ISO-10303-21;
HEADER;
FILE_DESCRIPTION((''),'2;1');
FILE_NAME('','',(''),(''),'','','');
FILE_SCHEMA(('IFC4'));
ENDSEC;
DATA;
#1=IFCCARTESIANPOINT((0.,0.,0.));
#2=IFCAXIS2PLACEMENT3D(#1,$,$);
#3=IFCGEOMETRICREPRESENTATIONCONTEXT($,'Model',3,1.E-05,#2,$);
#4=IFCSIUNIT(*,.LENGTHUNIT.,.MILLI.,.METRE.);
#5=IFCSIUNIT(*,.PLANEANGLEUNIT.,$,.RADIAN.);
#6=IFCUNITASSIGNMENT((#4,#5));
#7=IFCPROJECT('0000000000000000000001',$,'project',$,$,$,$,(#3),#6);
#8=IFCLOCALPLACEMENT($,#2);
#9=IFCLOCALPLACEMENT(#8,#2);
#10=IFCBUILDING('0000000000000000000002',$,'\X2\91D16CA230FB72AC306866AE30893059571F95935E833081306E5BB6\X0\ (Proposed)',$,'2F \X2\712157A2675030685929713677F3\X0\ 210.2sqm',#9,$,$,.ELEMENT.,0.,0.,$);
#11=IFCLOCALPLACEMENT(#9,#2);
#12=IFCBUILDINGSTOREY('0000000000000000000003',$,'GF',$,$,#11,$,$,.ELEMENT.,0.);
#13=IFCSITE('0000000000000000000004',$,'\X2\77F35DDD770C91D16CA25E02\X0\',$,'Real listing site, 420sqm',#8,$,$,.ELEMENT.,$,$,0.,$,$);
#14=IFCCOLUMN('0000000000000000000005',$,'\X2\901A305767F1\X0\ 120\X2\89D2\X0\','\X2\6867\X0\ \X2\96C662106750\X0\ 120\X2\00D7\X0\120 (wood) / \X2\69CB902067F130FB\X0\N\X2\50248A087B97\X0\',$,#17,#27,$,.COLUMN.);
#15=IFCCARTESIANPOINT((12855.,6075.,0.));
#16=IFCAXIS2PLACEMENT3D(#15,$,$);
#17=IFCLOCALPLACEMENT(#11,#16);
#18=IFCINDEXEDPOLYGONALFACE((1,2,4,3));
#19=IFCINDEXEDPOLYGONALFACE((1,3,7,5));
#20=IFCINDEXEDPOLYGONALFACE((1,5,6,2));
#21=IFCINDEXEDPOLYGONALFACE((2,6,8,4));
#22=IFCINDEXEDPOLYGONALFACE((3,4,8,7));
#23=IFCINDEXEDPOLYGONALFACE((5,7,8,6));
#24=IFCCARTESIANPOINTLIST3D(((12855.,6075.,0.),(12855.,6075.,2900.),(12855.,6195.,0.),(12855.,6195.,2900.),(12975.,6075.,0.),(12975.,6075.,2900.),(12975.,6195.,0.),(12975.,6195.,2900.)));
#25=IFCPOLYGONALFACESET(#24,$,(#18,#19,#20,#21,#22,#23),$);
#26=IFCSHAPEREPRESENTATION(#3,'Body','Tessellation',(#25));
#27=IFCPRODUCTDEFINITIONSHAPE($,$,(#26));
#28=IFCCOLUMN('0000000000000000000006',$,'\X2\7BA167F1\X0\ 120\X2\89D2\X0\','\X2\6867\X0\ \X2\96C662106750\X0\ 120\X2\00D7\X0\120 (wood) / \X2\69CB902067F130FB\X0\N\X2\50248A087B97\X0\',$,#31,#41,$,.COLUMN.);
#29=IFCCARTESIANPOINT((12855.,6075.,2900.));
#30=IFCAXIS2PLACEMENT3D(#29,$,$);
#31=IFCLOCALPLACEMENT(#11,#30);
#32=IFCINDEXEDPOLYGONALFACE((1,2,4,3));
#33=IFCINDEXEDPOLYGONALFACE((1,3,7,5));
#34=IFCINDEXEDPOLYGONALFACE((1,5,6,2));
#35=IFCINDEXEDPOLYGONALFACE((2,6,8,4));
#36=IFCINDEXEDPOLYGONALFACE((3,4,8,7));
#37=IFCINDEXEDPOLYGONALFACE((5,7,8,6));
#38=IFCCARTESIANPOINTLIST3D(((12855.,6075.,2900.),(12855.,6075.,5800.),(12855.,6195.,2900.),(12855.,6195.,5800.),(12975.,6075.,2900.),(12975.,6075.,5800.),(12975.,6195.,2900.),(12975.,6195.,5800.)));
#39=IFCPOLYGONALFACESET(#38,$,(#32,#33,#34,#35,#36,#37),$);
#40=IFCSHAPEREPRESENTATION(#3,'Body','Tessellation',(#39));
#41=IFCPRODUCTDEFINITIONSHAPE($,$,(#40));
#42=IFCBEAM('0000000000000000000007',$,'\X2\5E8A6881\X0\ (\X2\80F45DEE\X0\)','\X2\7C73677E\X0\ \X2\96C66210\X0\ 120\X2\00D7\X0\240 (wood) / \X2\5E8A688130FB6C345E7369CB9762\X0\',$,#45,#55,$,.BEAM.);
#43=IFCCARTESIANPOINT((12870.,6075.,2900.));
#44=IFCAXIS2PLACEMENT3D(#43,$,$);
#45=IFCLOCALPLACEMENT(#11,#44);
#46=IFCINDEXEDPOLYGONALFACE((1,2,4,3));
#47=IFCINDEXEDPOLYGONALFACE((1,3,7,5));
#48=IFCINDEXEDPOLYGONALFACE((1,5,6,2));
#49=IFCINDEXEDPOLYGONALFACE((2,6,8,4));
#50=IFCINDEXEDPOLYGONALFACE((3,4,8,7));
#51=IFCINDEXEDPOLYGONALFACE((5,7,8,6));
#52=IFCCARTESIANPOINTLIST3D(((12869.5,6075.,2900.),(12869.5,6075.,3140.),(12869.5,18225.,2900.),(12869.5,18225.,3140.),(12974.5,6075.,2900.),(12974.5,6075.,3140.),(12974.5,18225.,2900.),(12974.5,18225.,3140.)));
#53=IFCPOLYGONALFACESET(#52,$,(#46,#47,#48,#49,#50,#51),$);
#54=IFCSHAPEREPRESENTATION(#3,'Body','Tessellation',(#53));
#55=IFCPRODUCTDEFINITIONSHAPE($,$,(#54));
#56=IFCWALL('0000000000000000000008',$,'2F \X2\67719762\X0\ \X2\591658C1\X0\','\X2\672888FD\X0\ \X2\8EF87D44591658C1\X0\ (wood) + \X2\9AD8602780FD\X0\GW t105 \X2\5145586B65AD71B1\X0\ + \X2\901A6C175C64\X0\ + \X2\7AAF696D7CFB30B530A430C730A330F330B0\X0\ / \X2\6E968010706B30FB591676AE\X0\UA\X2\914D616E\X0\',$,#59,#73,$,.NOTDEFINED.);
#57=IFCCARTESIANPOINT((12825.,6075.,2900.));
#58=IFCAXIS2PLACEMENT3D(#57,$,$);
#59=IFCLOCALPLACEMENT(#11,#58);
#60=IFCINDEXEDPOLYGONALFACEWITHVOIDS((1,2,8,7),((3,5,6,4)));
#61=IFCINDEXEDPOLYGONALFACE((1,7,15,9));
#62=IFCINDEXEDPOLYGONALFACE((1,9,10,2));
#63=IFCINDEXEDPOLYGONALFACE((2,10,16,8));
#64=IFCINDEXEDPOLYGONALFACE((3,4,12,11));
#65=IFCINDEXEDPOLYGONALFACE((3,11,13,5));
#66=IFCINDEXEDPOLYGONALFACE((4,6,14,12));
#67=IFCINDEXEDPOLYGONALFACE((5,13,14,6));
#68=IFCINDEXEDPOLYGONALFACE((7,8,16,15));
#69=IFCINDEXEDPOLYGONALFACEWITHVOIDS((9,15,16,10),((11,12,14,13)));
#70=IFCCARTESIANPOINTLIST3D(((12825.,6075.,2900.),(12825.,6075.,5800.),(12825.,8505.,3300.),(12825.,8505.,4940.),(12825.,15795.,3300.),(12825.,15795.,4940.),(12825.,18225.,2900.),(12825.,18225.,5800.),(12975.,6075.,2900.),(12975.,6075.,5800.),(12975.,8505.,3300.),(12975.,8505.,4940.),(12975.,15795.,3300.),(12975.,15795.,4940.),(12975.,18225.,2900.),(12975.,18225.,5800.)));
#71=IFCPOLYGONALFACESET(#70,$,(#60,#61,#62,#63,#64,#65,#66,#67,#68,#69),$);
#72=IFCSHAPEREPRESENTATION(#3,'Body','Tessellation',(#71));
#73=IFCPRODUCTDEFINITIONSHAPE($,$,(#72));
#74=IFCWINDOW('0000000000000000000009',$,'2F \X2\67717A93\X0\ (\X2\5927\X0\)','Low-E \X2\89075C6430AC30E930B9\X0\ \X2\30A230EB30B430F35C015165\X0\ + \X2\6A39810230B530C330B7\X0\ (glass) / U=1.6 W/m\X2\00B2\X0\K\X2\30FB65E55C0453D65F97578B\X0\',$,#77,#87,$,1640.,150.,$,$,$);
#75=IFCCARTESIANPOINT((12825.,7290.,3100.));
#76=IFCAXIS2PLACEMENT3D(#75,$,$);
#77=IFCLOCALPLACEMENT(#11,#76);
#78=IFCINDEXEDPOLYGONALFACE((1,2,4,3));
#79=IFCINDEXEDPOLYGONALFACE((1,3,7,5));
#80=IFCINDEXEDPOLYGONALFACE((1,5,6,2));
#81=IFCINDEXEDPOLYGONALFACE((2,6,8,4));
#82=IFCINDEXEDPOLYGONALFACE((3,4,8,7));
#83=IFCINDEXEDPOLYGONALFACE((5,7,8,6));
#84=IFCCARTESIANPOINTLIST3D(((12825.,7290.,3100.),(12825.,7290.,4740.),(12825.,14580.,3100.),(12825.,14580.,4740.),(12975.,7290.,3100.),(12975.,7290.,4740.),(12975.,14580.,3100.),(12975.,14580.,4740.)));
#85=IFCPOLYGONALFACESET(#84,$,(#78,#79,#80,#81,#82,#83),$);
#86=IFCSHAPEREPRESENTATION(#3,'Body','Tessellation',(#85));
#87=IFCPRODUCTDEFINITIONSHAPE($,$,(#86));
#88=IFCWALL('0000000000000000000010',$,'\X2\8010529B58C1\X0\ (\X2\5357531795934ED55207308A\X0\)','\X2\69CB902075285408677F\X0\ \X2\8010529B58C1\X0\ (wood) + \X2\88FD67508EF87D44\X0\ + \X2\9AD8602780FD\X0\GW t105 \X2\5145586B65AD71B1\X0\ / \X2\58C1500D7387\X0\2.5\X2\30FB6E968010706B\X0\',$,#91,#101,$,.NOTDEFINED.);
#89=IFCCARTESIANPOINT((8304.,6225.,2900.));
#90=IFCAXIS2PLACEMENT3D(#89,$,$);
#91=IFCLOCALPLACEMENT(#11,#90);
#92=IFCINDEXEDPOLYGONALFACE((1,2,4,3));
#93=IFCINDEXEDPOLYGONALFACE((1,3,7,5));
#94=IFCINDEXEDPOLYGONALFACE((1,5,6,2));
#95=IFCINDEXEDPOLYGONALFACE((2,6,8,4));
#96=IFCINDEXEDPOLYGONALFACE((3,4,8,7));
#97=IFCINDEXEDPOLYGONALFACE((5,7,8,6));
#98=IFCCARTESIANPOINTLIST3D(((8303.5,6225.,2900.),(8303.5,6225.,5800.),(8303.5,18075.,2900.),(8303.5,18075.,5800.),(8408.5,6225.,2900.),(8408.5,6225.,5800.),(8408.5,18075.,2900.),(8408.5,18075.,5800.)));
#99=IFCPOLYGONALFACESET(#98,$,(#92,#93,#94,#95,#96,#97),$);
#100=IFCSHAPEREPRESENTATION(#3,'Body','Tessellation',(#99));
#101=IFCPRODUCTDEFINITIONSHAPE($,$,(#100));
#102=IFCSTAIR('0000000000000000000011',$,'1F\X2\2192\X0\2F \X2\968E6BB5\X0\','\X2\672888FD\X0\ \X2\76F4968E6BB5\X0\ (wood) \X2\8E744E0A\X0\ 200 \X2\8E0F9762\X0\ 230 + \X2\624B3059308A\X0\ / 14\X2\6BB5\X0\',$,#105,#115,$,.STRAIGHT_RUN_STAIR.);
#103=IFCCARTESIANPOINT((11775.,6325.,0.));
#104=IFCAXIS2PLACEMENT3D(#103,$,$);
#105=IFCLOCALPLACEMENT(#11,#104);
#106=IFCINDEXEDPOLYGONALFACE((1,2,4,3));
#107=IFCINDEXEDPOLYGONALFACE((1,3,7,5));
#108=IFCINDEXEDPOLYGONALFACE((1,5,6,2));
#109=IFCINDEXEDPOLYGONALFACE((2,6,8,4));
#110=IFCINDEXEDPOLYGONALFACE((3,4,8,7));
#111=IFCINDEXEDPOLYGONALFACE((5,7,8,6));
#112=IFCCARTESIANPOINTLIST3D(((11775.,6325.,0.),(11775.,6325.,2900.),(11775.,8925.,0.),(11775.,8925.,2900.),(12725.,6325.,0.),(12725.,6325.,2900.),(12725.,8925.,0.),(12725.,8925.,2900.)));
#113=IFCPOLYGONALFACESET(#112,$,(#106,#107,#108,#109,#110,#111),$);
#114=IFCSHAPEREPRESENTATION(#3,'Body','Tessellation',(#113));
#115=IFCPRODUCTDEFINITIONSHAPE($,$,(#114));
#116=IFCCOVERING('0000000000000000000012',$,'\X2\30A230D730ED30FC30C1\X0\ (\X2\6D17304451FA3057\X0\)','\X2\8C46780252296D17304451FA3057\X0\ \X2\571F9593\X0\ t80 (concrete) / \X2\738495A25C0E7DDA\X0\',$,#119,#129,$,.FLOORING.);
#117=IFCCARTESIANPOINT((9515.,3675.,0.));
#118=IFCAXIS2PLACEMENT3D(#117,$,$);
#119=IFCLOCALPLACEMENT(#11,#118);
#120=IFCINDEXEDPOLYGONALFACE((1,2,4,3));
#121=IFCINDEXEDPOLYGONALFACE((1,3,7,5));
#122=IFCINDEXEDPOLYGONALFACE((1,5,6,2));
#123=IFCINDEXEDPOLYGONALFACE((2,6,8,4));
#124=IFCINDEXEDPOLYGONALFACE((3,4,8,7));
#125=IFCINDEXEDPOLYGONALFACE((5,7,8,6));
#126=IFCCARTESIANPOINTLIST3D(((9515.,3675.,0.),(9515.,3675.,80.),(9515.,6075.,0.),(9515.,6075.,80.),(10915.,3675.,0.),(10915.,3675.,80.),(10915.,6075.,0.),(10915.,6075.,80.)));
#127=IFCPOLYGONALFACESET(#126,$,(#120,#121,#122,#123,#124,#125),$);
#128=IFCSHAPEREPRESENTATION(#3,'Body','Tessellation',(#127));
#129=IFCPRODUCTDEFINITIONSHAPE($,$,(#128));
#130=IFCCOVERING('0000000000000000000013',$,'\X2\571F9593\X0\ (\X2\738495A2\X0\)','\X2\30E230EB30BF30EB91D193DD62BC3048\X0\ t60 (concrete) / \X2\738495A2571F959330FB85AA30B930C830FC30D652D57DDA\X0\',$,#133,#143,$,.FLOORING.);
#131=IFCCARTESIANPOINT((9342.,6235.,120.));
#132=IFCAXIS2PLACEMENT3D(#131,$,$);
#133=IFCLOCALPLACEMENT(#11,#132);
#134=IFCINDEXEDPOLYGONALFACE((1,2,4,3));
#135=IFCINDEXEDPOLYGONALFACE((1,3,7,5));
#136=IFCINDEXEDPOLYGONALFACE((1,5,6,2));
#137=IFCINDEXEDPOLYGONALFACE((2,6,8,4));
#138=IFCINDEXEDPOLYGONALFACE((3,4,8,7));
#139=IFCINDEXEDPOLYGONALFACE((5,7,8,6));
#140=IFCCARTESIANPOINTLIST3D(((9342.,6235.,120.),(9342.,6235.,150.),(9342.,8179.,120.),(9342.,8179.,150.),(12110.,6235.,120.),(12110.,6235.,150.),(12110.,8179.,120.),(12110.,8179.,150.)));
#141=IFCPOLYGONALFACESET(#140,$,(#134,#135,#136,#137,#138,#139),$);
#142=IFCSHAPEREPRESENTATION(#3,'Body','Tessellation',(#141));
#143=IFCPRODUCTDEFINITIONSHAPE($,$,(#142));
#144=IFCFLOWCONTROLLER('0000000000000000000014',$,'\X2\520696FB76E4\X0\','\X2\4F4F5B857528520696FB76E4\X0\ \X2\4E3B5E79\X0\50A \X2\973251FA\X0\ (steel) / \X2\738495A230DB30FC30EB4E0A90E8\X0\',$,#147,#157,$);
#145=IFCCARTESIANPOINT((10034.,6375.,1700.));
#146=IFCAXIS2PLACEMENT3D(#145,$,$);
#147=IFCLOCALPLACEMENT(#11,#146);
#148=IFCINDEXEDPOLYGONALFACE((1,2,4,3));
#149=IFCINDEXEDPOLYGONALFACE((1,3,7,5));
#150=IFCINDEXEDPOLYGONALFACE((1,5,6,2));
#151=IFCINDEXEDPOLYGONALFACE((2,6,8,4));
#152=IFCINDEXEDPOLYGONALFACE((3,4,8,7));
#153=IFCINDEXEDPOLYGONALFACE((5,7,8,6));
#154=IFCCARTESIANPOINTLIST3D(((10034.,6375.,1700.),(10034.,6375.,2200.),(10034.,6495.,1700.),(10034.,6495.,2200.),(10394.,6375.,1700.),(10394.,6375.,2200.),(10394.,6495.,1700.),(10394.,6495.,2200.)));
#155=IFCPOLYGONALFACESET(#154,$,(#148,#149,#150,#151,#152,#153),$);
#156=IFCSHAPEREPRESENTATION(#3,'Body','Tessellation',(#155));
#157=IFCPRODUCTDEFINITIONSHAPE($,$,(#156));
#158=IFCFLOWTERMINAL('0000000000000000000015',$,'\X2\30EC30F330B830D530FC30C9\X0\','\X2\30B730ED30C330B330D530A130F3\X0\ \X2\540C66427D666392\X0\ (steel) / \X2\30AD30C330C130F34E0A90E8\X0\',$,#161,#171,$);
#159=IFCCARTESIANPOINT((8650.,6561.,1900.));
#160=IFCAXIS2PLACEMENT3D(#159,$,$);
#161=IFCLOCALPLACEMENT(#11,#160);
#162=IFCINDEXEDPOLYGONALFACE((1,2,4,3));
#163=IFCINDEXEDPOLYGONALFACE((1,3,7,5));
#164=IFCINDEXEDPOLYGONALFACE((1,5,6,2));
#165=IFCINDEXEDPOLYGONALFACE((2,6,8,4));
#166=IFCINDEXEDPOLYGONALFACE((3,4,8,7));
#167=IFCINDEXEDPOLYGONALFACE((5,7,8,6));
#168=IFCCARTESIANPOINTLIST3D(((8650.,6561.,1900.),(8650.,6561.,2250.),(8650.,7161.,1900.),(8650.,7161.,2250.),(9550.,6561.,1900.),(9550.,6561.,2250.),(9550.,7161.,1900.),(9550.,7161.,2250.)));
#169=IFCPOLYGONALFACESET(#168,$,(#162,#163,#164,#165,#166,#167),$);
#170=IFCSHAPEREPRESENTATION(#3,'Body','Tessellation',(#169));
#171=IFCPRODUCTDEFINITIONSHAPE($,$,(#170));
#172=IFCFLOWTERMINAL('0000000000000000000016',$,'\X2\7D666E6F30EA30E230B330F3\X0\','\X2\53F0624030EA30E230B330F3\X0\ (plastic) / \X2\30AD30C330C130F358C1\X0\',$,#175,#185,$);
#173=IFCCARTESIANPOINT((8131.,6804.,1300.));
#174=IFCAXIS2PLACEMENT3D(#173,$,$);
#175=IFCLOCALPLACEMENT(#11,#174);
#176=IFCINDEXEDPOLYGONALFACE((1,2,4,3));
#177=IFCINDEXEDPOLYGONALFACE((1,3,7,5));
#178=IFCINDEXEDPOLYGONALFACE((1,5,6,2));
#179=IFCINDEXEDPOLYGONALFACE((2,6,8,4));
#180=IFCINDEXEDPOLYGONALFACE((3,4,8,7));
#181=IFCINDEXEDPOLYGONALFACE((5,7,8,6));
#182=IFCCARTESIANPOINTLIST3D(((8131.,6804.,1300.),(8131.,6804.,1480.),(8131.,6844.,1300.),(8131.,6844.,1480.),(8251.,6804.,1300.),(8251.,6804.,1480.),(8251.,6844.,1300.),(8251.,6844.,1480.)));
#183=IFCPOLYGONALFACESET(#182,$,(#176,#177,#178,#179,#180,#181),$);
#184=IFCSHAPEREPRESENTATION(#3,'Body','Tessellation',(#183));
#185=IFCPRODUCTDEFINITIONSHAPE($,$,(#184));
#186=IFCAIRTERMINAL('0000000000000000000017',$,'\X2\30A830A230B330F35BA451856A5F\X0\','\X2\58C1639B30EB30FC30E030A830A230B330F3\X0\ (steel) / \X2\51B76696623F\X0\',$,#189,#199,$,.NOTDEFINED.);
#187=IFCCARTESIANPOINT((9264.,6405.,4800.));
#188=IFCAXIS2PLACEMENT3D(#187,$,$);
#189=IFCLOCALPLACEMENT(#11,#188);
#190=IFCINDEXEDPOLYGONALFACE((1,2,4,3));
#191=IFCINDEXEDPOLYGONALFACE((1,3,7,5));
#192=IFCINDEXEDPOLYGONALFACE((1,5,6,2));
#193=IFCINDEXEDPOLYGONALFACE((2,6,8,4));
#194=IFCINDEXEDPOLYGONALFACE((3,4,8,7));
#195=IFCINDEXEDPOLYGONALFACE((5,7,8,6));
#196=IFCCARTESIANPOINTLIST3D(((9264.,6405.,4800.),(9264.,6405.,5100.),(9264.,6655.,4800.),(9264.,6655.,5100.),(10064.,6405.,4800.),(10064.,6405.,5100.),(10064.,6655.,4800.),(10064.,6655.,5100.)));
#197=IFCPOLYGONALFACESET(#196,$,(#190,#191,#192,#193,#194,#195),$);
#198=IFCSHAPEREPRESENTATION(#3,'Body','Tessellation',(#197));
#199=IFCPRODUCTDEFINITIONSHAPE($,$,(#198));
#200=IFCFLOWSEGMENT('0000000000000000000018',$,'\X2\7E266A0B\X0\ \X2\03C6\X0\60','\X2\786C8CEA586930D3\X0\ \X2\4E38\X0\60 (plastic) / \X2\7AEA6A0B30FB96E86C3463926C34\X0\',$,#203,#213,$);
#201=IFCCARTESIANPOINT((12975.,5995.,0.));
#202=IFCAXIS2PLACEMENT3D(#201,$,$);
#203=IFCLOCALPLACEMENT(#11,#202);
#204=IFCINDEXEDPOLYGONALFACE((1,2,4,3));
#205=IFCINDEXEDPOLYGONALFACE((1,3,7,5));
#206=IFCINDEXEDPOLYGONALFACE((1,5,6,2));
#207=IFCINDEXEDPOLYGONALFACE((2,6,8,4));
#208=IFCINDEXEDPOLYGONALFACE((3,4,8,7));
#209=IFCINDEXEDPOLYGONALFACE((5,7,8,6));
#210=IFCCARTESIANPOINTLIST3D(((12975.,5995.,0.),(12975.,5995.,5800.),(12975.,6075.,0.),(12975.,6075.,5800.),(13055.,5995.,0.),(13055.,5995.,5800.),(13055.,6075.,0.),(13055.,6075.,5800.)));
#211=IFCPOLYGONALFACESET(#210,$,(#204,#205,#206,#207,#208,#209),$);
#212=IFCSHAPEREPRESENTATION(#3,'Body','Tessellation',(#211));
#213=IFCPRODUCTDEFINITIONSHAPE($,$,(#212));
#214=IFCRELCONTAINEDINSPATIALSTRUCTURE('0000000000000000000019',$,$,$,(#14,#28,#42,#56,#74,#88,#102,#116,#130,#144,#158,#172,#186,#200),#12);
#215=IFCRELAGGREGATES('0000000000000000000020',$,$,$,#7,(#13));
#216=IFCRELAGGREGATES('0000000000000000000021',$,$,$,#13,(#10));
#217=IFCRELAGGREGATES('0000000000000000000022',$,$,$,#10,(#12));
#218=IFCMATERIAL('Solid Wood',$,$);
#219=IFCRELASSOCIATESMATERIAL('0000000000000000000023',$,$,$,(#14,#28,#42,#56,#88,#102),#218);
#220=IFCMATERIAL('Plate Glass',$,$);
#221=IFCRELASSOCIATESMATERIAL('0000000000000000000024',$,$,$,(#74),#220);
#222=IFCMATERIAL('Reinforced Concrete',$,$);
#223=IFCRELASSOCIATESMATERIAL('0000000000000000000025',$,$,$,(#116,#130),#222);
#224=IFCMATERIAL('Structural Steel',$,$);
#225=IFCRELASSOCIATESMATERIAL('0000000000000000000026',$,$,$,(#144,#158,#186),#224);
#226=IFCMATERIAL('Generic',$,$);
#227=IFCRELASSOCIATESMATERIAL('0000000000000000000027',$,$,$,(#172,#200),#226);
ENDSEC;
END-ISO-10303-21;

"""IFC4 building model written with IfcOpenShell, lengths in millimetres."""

from ifc_helpers import new_model, si_unit, frame, frame_2d, origin, place, context, project, spatial, rectangle, extrude, material, element, fill, save


model = new_model("IFC4")

# Units and contexts
model_context = context("Model", 3, precision=1e-05, world=origin())
ifc_project = project(units=[si_unit("LENGTHUNIT", "METRE", prefix="MILLI"), si_unit("PLANEANGLEUNIT", "RADIAN")], contexts=[model_context])

# Site, building, storey
site_placement = place(None, origin())
site = spatial("IfcSite", under=ifc_project, at=site_placement, Name="石川県金沢市", ObjectType="Real listing site, 420sqm", CompositionType="ELEMENT", RefElevation=0.0)
building_placement = place(site_placement, origin())
building = spatial("IfcBuilding", under=site, at=building_placement, Name="金沢・犬と暮らす土間広めの家 (Proposed)", ObjectType="2F 無垢材と天然石 210.2sqm", CompositionType="ELEMENT", ElevationOfRefHeight=0.0, ElevationOfTerrain=0.0)
storey_placement = place(building_placement, origin())
storey = spatial("IfcBuildingStorey", under=building, at=storey_placement, Name="GF", CompositionType="ELEMENT", Elevation=0.0)

# Columns
ifc_material_1 = material(Name="Solid Wood")
column_1_placement = place(storey_placement, frame((12855.0, 6075.0, 0.0)))
element("IfcColumn", 1, at=column_1_placement, inside=storey, material=ifc_material_1, Name="通し柱 120角", Description="桧 集成材 120×120 (wood) / 構造柱・N値計算", PredefinedType="COLUMN", context=model_context, shape_type="SweptSolid", body=[
    extrude(rectangle(XDim=120.0, YDim=120.0, at=frame_2d((60.0, 60.0))), frame((12855.0, 6075.0, 0.0)), (0.0, 0.0, 1.0), 2900.0),
])
column_2_placement = place(storey_placement, frame((12855.0, 6075.0, 2900.0)))
element("IfcColumn", 2, at=column_2_placement, inside=storey, material=ifc_material_1, Name="管柱 120角", Description="桧 集成材 120×120 (wood) / 構造柱・N値計算", PredefinedType="COLUMN", context=model_context, shape_type="SweptSolid", body=[
    extrude(rectangle(XDim=120.0, YDim=120.0, at=frame_2d((60.0, 60.0))), frame((12855.0, 6075.0, 2900.0)), (0.0, 0.0, 1.0), 2900.0),
])

# Beam
beam_1_placement = place(storey_placement, frame((12870.0, 6075.0, 2900.0)))
element("IfcBeam", 3, at=beam_1_placement, inside=storey, material=ifc_material_1, Name="床梁 (胴差)", Description="米松 集成 120×240 (wood) / 床梁・水平構面", PredefinedType="BEAM", context=model_context, shape_type="SweptSolid", body=[
    extrude(rectangle(XDim=105.0, YDim=12150.0, at=frame_2d((52.0, 6075.0))), frame((12870.0, 6075.0, 2900.0)), (0.0, 0.0, 1.0), 240.0),
])

# Shared definitions
ifc_material_2 = material(Name="Plate Glass")

# Wall, opening, window
wall_1_placement = place(storey_placement, frame((12825.0, 6075.0, 2900.0)))
wall_1 = element("IfcWall", 4, at=wall_1_placement, inside=storey, material=ifc_material_1, Name="2F 東面 外壁", Description="木製 軸組外壁 (wood) + 高性能GW t105 充填断熱 + 通気層 + 窯業系サイディング / 準耐火・外皮UA配慮", PredefinedType="NOTDEFINED", context=model_context, shape_type="SweptSolid", body=[
    extrude(rectangle(XDim=150.0, YDim=12150.0, at=frame_2d((75.0, 6075.0))), frame((12825.0, 6075.0, 2900.0)), (0.0, 0.0, 1.0), 2900.0),
])
opening_1_placement = place(storey_placement, frame((12825.0, 7290.0, 3100.0)))
opening_1 = element("IfcOpeningElement", 5, at=opening_1_placement, cuts=wall_1, PredefinedType="NOTDEFINED", context=model_context, shape_type="SweptSolid", body=[
    extrude(rectangle(XDim=150.0, YDim=7290.0, at=frame_2d((75.0, 3645.0))), frame((12825.0, 7290.0, 3100.0)), (0.0, 0.0, 1.0), 1640.0),
])
window_1_placement = place(storey_placement, frame((12825.0, 7290.0, 3100.0)))
window_1 = element("IfcWindow", 6, at=window_1_placement, inside=storey, material=ifc_material_2, Name="2F 東窓 (大)", Description="Low-E 複層ガラス アルゴン封入 + 樹脂サッシ (glass) / U=1.6 W/m²K・日射取得型", OverallHeight=1640.0, OverallWidth=150.0, context=model_context, shape_type="SweptSolid", body=[
    extrude(rectangle(XDim=150.0, YDim=7290.0, at=frame_2d((75.0, 3645.0))), frame((12825.0, 7290.0, 3100.0)), (0.0, 0.0, 1.0), 1640.0),
])
fill(opening_1, window_1)

# Wall
wall_2_placement = place(storey_placement, frame((8304.0, 6225.0, 2900.0)))
element("IfcWall", 7, at=wall_2_placement, inside=storey, material=ifc_material_1, Name="耐力壁 (南北間仕切り)", Description="構造用合板 耐力壁 (wood) + 製材軸組 + 高性能GW t105 充填断熱 / 壁倍率2.5・準耐火", PredefinedType="NOTDEFINED", context=model_context, shape_type="SweptSolid", body=[
    extrude(rectangle(XDim=105.0, YDim=11850.0, at=frame_2d((52.0, 5925.0))), frame((8304.0, 6225.0, 2900.0)), (0.0, 0.0, 1.0), 2900.0),
])

# Stair
stair_placement = place(storey_placement, frame((11775.0, 6325.0, 0.0)))
element("IfcStair", 8, at=stair_placement, inside=storey, material=ifc_material_1, Name="1F→2F 階段", Description="木製 直階段 (wood) 蹴上 200 踏面 230 + 手すり / 14段", PredefinedType="STRAIGHT_RUN_STAIR", context=model_context, shape_type="SweptSolid", body=[
    extrude(rectangle(XDim=950.0, YDim=2600.0, at=frame_2d((475.0, 1300.0))), frame((11775.0, 6325.0, 0.0)), (0.0, 0.0, 1.0), 2900.0),
])

# Coverings
ifc_material_3 = material(Name="Reinforced Concrete")
covering_1_placement = place(storey_placement, frame((9515.0, 3675.0, 0.0)))
element("IfcCovering", 9, at=covering_1_placement, inside=storey, material=ifc_material_3, Name="アプローチ (洗い出し)", Description="豆砂利洗い出し 土間 t80 (concrete) / 玄関導線", PredefinedType="FLOORING", context=model_context, shape_type="SweptSolid", body=[
    extrude(rectangle(XDim=1400.0, YDim=2400.0, at=frame_2d((700.0, 1200.0))), frame((9515.0, 3675.0, 0.0)), (0.0, 0.0, 1.0), 80.0),
])
covering_2_placement = place(storey_placement, frame((9342.0, 6235.0, 120.0)))
element("IfcCovering", 10, at=covering_2_placement, inside=storey, material=ifc_material_3, Name="土間 (玄関)", Description="モルタル金鏝押え t60 (concrete) / 玄関土間・薪ストーブ動線", PredefinedType="FLOORING", context=model_context, shape_type="SweptSolid", body=[
    extrude(rectangle(XDim=2768.0, YDim=1944.0, at=frame_2d((1384.0, 972.0))), frame((9342.0, 6235.0, 120.0)), (0.0, 0.0, 1.0), 30.0),
])

# Flow controller
ifc_material_4 = material(Name="Structural Steel")
flow_controller_placement = place(storey_placement, frame((10034.0, 6375.0, 1700.0)))
element("IfcFlowController", 11, at=flow_controller_placement, inside=storey, material=ifc_material_4, Name="分電盤", Description="住宅用分電盤 主幹50A 露出 (steel) / 玄関ホール上部", context=model_context, shape_type="SweptSolid", body=[
    extrude(rectangle(XDim=360.0, YDim=120.0, at=frame_2d((180.0, 60.0))), frame((10034.0, 6375.0, 1700.0)), (0.0, 0.0, 1.0), 500.0),
])

# Flow terminals
flow_terminal_1_placement = place(storey_placement, frame((8650.0, 6561.0, 1900.0)))
element("IfcFlowTerminal", 12, at=flow_terminal_1_placement, inside=storey, material=ifc_material_4, Name="レンジフード", Description="シロッコファン 同時給排 (steel) / キッチン上部", context=model_context, shape_type="SweptSolid", body=[
    extrude(rectangle(XDim=900.0, YDim=600.0, at=frame_2d((450.0, 300.0))), frame((8650.0, 6561.0, 1900.0)), (0.0, 0.0, 1.0), 350.0),
])
ifc_material_5 = material(Name="Generic")
flow_terminal_2_placement = place(storey_placement, frame((8131.0, 6804.0, 1300.0)))
element("IfcFlowTerminal", 13, at=flow_terminal_2_placement, inside=storey, material=ifc_material_5, Name="給湯リモコン", Description="台所リモコン (plastic) / キッチン壁", context=model_context, shape_type="SweptSolid", body=[
    extrude(rectangle(XDim=120.0, YDim=40.0, at=frame_2d((60.0, 20.0))), frame((8131.0, 6804.0, 1300.0)), (0.0, 0.0, 1.0), 180.0),
])

# Air terminal
air_terminal_placement = place(storey_placement, frame((9264.0, 6405.0, 4800.0)))
element("IfcAirTerminal", 14, at=air_terminal_placement, inside=storey, material=ifc_material_4, Name="エアコン室内機", Description="壁掛ルームエアコン (steel) / 冷暖房", PredefinedType="NOTDEFINED", context=model_context, shape_type="SweptSolid", body=[
    extrude(rectangle(XDim=800.0, YDim=250.0, at=frame_2d((400.0, 125.0))), frame((9264.0, 6405.0, 4800.0)), (0.0, 0.0, 1.0), 300.0),
])

# Flow segment
flow_segment_placement = place(storey_placement, frame((12975.0, 5995.0, 0.0)))
element("IfcFlowSegment", 15, at=flow_segment_placement, inside=storey, material=ifc_material_5, Name="縦樋 φ60", Description="硬質塩ビ 丸60 (plastic) / 竪樋・雨水排水", context=model_context, shape_type="SweptSolid", body=[
    extrude(rectangle(XDim=80.0, YDim=80.0, at=frame_2d((40.0, 40.0))), frame((12975.0, 5995.0, 0.0)), (0.0, 0.0, 1.0), 5800.0),
])

save(model, "model.ifc")
